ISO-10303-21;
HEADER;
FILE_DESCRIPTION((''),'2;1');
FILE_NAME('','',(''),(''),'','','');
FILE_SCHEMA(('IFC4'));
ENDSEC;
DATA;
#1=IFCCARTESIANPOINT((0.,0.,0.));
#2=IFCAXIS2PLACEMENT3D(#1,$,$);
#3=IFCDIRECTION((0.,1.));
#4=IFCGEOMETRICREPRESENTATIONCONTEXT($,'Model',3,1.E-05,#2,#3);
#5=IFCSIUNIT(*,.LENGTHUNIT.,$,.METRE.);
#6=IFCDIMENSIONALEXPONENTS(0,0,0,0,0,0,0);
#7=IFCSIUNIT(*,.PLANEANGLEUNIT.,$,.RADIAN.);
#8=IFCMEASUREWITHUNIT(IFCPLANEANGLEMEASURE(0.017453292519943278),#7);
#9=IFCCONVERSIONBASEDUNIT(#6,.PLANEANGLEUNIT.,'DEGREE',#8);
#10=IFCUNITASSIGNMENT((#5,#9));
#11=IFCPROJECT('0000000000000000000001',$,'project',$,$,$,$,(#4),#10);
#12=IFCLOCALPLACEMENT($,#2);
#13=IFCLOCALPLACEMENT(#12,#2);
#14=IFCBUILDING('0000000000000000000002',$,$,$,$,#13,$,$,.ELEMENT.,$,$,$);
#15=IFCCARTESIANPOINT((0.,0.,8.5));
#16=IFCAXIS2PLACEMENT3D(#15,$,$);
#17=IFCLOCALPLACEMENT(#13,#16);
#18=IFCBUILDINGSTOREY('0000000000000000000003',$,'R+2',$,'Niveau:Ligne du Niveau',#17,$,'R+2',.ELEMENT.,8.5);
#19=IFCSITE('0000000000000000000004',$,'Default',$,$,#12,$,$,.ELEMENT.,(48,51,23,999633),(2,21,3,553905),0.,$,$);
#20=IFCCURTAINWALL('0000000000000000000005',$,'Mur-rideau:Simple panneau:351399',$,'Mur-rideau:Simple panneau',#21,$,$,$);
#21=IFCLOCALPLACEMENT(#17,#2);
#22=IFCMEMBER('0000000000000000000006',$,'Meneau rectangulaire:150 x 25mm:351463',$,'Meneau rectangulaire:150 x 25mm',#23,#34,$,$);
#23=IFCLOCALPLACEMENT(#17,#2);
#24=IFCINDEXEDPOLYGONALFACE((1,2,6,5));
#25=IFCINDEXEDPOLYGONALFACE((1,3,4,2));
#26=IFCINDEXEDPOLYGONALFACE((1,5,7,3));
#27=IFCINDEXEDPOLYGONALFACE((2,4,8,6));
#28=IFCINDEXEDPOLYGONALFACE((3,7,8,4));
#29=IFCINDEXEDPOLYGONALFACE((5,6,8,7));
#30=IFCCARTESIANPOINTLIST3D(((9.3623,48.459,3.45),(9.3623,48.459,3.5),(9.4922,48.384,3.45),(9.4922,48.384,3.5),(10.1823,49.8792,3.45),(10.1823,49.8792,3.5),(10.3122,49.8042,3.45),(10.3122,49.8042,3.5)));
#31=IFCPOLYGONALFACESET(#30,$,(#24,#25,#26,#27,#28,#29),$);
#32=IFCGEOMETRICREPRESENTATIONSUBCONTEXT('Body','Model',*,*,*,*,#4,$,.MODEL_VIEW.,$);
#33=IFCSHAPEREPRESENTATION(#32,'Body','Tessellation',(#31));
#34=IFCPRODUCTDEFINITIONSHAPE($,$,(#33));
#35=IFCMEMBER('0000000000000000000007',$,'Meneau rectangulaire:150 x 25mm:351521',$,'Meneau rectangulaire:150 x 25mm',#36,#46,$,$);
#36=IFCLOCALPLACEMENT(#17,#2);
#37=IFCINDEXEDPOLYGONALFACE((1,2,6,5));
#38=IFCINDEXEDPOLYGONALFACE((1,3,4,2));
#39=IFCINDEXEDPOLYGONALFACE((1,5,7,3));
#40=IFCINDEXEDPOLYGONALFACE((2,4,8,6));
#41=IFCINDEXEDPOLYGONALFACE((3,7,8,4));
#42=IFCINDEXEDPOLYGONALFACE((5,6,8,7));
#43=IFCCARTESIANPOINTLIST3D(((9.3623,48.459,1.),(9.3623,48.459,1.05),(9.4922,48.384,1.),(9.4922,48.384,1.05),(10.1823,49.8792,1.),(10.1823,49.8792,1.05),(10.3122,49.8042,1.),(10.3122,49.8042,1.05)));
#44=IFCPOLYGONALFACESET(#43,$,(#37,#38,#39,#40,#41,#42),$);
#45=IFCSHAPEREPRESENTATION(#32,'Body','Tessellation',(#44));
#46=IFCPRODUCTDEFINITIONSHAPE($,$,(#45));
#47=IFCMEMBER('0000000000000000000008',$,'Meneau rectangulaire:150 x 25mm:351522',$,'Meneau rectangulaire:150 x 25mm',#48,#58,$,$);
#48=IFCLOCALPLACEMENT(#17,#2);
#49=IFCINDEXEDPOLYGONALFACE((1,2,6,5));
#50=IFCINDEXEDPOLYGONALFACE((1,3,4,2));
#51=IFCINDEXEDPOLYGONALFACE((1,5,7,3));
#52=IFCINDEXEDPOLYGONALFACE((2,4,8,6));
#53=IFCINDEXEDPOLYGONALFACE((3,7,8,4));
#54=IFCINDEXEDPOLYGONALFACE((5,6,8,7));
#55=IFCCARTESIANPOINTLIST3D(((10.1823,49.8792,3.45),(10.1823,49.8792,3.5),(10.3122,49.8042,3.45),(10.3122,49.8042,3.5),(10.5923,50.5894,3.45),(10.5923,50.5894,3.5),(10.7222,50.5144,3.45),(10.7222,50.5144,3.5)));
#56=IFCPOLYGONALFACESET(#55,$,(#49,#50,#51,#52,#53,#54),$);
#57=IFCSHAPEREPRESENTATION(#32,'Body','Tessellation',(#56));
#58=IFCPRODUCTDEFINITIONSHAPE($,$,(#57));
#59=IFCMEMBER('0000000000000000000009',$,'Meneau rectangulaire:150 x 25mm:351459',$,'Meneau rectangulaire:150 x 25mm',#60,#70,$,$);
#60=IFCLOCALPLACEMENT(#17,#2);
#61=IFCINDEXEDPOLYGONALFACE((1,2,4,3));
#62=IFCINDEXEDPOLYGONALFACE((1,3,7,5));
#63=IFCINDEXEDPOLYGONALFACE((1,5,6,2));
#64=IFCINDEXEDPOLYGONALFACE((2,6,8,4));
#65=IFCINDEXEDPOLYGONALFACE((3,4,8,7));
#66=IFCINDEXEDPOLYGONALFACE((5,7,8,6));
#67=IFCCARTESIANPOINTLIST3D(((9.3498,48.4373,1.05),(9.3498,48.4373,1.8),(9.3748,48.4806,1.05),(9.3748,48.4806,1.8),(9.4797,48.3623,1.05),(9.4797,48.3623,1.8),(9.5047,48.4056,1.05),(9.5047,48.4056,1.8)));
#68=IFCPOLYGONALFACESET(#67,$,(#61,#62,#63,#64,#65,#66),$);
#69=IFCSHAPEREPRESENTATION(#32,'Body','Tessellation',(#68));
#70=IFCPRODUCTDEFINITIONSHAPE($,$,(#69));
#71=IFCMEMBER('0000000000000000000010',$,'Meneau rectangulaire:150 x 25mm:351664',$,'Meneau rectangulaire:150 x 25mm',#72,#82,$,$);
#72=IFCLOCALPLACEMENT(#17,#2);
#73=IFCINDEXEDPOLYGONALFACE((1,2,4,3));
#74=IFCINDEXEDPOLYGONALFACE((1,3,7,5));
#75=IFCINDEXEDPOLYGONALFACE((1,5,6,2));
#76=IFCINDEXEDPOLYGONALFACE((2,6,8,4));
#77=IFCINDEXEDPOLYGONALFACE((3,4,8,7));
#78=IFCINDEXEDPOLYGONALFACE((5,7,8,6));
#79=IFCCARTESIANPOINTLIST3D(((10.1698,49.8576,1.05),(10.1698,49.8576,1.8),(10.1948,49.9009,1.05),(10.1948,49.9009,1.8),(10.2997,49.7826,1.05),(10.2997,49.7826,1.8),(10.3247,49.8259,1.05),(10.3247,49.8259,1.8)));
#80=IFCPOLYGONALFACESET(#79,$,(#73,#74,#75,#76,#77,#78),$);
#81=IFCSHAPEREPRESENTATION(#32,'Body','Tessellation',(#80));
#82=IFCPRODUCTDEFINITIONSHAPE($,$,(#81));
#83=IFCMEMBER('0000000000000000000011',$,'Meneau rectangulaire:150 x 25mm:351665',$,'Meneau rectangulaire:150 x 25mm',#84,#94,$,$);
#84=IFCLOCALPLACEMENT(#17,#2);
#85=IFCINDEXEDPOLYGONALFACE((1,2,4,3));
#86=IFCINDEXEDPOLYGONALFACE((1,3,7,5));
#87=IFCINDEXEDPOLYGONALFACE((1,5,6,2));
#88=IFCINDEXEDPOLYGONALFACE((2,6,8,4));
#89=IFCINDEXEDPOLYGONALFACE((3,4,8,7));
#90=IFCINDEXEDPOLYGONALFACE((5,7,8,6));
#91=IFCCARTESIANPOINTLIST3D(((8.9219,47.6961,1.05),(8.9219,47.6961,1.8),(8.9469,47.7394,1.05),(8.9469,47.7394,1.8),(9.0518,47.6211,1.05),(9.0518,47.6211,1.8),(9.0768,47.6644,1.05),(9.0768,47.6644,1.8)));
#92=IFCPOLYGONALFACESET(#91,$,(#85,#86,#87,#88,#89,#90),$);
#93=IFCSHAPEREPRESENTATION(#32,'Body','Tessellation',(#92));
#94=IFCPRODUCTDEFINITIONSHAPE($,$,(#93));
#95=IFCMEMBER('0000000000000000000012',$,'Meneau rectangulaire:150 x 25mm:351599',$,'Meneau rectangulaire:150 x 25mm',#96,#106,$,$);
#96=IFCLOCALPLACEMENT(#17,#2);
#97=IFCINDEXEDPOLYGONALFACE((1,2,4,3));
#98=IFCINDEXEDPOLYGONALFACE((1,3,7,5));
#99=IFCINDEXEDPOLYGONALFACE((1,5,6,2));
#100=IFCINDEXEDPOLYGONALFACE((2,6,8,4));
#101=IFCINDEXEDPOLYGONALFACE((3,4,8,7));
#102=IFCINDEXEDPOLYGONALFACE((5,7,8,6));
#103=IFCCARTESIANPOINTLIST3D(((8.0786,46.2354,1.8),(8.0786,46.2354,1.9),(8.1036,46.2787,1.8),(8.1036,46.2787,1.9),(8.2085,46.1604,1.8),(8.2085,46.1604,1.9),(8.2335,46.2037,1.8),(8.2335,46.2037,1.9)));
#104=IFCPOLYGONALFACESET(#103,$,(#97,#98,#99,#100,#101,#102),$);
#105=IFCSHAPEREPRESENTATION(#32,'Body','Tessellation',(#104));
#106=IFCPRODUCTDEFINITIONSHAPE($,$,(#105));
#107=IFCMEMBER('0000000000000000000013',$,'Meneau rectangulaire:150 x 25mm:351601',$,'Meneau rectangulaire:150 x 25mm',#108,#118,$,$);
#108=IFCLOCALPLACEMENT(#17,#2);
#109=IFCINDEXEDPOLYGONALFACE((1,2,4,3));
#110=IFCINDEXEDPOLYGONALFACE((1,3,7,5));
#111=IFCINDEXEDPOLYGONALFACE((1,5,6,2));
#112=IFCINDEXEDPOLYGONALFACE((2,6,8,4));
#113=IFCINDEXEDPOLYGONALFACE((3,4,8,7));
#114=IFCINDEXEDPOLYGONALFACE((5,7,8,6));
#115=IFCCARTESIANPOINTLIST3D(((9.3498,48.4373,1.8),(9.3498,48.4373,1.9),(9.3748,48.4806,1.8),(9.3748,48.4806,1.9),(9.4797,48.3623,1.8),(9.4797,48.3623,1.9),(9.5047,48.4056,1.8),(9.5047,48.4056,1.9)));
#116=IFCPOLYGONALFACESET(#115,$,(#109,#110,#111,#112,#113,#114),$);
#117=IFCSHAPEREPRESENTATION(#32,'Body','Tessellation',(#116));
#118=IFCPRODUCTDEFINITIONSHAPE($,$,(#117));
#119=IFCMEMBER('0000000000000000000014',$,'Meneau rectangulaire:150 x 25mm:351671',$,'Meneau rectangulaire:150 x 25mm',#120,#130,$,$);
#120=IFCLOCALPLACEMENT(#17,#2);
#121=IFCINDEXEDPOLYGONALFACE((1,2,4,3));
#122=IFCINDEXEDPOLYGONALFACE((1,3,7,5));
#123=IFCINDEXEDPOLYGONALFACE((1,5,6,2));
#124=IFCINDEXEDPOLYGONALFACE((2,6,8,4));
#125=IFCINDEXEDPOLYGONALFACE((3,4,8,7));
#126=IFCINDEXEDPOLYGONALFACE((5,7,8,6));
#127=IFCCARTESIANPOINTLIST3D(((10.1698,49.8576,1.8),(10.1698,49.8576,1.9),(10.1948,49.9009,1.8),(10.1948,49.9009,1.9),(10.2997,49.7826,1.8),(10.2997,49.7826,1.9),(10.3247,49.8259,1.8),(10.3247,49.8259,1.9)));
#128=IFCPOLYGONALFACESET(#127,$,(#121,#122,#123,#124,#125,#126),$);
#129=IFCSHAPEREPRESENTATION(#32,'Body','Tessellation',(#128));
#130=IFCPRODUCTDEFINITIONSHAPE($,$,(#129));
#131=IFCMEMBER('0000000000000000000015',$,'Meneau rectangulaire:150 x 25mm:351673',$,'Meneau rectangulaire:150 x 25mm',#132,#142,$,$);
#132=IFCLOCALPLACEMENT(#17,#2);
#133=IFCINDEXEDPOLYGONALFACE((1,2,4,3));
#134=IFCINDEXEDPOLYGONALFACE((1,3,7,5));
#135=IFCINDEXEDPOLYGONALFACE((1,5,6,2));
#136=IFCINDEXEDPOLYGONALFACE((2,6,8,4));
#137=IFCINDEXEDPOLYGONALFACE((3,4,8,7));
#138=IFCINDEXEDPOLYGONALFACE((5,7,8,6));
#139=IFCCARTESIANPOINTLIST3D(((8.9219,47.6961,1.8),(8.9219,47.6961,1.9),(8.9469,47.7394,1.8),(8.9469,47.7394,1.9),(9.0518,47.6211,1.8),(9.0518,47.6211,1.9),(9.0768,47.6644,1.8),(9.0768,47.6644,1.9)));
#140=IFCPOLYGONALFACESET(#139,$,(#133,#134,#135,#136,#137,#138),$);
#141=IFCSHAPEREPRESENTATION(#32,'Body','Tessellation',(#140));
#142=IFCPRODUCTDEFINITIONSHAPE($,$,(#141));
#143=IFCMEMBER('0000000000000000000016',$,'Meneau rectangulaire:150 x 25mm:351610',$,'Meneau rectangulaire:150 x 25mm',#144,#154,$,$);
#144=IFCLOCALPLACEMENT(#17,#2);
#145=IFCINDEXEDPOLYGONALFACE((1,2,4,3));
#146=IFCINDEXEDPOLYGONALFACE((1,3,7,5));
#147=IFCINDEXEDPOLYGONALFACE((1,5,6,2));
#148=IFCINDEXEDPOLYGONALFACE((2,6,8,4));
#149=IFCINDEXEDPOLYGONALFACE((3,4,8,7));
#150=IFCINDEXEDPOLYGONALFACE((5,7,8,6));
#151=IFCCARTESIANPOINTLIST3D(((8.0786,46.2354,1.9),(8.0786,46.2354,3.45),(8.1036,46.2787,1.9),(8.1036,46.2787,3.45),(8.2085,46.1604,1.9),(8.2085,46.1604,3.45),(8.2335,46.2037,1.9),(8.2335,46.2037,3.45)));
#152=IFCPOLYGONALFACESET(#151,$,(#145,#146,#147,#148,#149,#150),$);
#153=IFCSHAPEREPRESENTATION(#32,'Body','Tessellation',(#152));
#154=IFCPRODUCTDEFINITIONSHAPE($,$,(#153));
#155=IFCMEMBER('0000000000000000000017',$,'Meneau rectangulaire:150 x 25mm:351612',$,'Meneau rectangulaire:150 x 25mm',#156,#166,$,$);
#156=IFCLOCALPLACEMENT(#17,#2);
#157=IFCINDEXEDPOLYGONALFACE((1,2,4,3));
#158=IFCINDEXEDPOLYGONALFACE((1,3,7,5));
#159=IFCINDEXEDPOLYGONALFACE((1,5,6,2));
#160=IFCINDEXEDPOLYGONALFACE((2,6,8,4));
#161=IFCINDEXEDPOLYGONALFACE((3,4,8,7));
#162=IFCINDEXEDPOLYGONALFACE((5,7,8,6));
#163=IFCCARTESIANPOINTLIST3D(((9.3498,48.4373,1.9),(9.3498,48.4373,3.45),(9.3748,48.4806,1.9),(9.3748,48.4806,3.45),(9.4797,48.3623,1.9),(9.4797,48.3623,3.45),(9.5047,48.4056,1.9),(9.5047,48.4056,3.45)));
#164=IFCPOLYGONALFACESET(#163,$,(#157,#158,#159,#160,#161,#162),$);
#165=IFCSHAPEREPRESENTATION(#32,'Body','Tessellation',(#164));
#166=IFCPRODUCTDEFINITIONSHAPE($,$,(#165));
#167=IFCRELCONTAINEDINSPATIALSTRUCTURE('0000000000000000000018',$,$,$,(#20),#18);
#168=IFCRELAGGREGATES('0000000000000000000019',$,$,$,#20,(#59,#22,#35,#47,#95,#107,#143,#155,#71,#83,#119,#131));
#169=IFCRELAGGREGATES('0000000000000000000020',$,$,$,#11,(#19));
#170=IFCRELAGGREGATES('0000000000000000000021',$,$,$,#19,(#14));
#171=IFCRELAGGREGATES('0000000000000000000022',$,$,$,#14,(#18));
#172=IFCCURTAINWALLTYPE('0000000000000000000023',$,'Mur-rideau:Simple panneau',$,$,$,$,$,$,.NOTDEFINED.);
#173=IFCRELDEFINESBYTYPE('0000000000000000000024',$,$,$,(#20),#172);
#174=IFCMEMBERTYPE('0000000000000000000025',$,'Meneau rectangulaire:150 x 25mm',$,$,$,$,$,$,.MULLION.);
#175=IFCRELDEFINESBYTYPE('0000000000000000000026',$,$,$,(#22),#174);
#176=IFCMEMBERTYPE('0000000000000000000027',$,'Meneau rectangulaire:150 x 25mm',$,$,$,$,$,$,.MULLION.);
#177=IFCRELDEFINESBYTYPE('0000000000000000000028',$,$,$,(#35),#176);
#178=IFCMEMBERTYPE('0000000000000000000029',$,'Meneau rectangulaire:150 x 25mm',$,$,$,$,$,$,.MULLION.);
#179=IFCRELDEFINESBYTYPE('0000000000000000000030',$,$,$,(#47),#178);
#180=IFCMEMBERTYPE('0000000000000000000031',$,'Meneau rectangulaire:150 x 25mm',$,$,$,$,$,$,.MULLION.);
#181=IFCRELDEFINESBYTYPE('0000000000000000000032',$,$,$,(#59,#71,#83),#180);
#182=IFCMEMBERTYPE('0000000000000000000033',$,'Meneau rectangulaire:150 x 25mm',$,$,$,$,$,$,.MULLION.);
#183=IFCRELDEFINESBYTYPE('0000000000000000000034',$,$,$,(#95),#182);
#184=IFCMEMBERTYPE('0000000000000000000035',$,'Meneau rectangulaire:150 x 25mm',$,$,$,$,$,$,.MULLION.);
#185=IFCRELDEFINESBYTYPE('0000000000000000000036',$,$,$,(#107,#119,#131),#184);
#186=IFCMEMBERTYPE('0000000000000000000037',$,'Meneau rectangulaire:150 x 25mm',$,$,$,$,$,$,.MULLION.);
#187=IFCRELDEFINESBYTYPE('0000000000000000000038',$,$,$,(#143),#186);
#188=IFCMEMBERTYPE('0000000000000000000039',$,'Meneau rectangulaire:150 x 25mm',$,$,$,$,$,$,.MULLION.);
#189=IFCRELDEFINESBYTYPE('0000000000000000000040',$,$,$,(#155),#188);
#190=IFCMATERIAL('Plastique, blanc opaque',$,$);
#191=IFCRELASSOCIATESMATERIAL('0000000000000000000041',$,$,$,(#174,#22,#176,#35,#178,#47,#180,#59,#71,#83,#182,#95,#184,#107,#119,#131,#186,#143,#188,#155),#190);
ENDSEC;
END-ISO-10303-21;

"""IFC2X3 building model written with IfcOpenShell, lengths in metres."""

from ifc_helpers import new_model, entity, si_unit, converted_unit, direction, frame, origin, origin_2d_with_axis, place, context, subcontext, project, spatial, rectangle, extrude, source, transform, mapped, material, type_object, type_shapes, element, aggregate, save


model = new_model("IFC2X3")

# Units and contexts
model_context = context("Model", 3, precision=1e-05, world=origin(), true_north=direction((0.0, 1.0)))
body_context = subcontext(model_context, "Body", "Model", "MODEL_VIEW")
ifc_project = project(units=[si_unit("LENGTHUNIT", "METRE"), converted_unit("PLANEANGLEUNIT", "DEGREE", entity("IfcPlaneAngleMeasure", 0.017453292519943278), si_unit("PLANEANGLEUNIT", "RADIAN"), dimensions=[0, 0, 0, 0, 0, 0, 0])], contexts=[model_context])

# Site, building, storey
site_placement = place(None, origin())
site = spatial("IfcSite", under=ifc_project, at=site_placement, Name="Default", CompositionType="ELEMENT", RefLatitude=(48, 51, 23, 999633), RefLongitude=(2, 21, 3, 553905), RefElevation=0.0)
building_placement = place(site_placement, origin())
building = spatial("IfcBuilding", under=site, at=building_placement, CompositionType="ELEMENT")
storey_placement = place(building_placement, frame((0.0, 0.0, 8.5)))
storey = spatial("IfcBuildingStorey", under=building, at=storey_placement, Name="R+2", ObjectType="Niveau:Ligne du Niveau", LongName="R+2", CompositionType="ELEMENT", Elevation=8.5)

# Curtain wall, members
curtain_wall_type = type_object("IfcCurtainWallType", Name="Mur-rideau:Simple panneau", PredefinedType="NOTDEFINED")
curtain_wall_placement = place(storey_placement, frame((0.0, 0.0, -8.5)))
curtain_wall = element("IfcCurtainWall", 1, at=curtain_wall_placement, inside=storey, type_object=curtain_wall_type, Name="Mur-rideau:Simple panneau:351399", ObjectType="Mur-rideau:Simple panneau")
ifc_material_1 = material(Name="Plastique, blanc opaque")
member_type_1 = type_object("IfcMemberType", Name="Meneau rectangulaire:150 x 25mm", PredefinedType="MULLION", material=ifc_material_1)
shared_shape_1 = source(origin(), body_context, "Body", "SweptSolid", [
    extrude(rectangle(XDim=0.05, YDim=0.15, at=origin_2d_with_axis()), frame((-0.025, 0.0, -1.64), z_axis=(0.0, 0.0, 1.0), x_axis=(-1.0, 0.0, 0.0)), (0.0, 0.0, 1.0), 1.64),
])
type_shapes(member_type_1, [shared_shape_1])
member_1_placement = place(curtain_wall_placement, frame((9.4273, 48.4215, 12.0), z_axis=(-0.5, -0.866025, 0.0), x_axis=(0.0, 0.0, 1.0)))
member_1 = element("IfcMember", 2, at=member_1_placement, type_object=member_type_1, material=ifc_material_1, Name="Meneau rectangulaire:150 x 25mm:351463", ObjectType="Meneau rectangulaire:150 x 25mm", context=body_context, shape_type="MappedRepresentation", body=[
    mapped(shared_shape_1, transform((0.0, 0.0, 0.0), scale=1.0)),
])
member_type_2 = type_object("IfcMemberType", Name="Meneau rectangulaire:150 x 25mm", PredefinedType="MULLION", material=ifc_material_1)
shared_shape_2 = source(origin(), body_context, "Body", "SweptSolid", [
    extrude(rectangle(XDim=0.05, YDim=0.15, at=origin_2d_with_axis()), frame((-0.025, 0.0, -1.64), z_axis=(0.0, 0.0, 1.0), x_axis=(-1.0, 0.0, 0.0)), (0.0, 0.0, 1.0), 1.64),
])
type_shapes(member_type_2, [shared_shape_2])
member_2_placement = place(curtain_wall_placement, frame((10.2473, 49.8417, 9.5), z_axis=(0.5, 0.866025, 0.0), x_axis=(0.0, 0.0, -1.0)))
member_2 = element("IfcMember", 3, at=member_2_placement, type_object=member_type_2, material=ifc_material_1, Name="Meneau rectangulaire:150 x 25mm:351521", ObjectType="Meneau rectangulaire:150 x 25mm", context=body_context, shape_type="MappedRepresentation", body=[
    mapped(shared_shape_2, transform((0.0, 0.0, 0.0), scale=1.0)),
])
member_type_3 = type_object("IfcMemberType", Name="Meneau rectangulaire:150 x 25mm", PredefinedType="MULLION", material=ifc_material_1)
shared_shape_3 = source(origin(), body_context, "Body", "SweptSolid", [
    extrude(rectangle(XDim=0.05, YDim=0.15, at=origin_2d_with_axis()), frame((-0.025, 0.0, -0.82), z_axis=(0.0, 0.0, 1.0), x_axis=(-1.0, 0.0, 0.0)), (0.0, 0.0, 1.0), 0.82),
])
type_shapes(member_type_3, [shared_shape_3])
member_3_placement = place(curtain_wall_placement, frame((10.2473, 49.8417, 12.0), z_axis=(-0.5, -0.866025, 0.0), x_axis=(0.0, 0.0, 1.0)))
member_3 = element("IfcMember", 4, at=member_3_placement, type_object=member_type_3, material=ifc_material_1, Name="Meneau rectangulaire:150 x 25mm:351522", ObjectType="Meneau rectangulaire:150 x 25mm", context=body_context, shape_type="MappedRepresentation", body=[
    mapped(shared_shape_3, transform((0.0, 0.0, 0.0), scale=1.0)),
])
member_type_4 = type_object("IfcMemberType", Name="Meneau rectangulaire:150 x 25mm", PredefinedType="MULLION", material=ifc_material_1)
shared_shape_4 = source(origin(), body_context, "Body", "SweptSolid", [
    extrude(rectangle(XDim=0.05, YDim=0.15, at=origin_2d_with_axis()), frame((0.0, 0.0, -0.75), z_axis=(0.0, 0.0, 1.0), x_axis=(-1.0, 0.0, 0.0)), (0.0, 0.0, 1.0), 0.75),
])
type_shapes(member_type_4, [shared_shape_4])
member_4_placement = place(curtain_wall_placement, frame((9.4273, 48.4215, 9.55), z_axis=(0.0, 0.0, -1.0), x_axis=(-0.5, -0.866025, 0.0)))
member_4 = element("IfcMember", 5, at=member_4_placement, type_object=member_type_4, material=ifc_material_1, Name="Meneau rectangulaire:150 x 25mm:351459", ObjectType="Meneau rectangulaire:150 x 25mm", context=body_context, shape_type="MappedRepresentation", body=[
    mapped(shared_shape_4, transform((0.0, 0.0, 0.0), scale=1.0)),
])
member_5_placement = place(curtain_wall_placement, frame((10.2473, 49.8417, 9.55), z_axis=(0.0, 0.0, -1.0), x_axis=(-0.5, -0.866025, 0.0)))
member_5 = element("IfcMember", 6, at=member_5_placement, type_object=member_type_4, material=ifc_material_1, Name="Meneau rectangulaire:150 x 25mm:351664", ObjectType="Meneau rectangulaire:150 x 25mm", context=body_context, shape_type="MappedRepresentation", body=[
    mapped(shared_shape_4, transform((0.0, 0.0, 0.0), scale=1.0)),
])
member_6_placement = place(curtain_wall_placement, frame((8.9994, 47.6803, 9.55), z_axis=(0.0, 0.0, -1.0), x_axis=(-0.5, -0.866025, 0.0)))
member_6 = element("IfcMember", 7, at=member_6_placement, type_object=member_type_4, material=ifc_material_1, Name="Meneau rectangulaire:150 x 25mm:351665", ObjectType="Meneau rectangulaire:150 x 25mm", context=body_context, shape_type="MappedRepresentation", body=[
    mapped(shared_shape_4, transform((0.0, 0.0, 0.0), scale=1.0)),
])
member_type_5 = type_object("IfcMemberType", Name="Meneau rectangulaire:150 x 25mm", PredefinedType="MULLION", material=ifc_material_1)
shared_shape_5 = source(origin(), body_context, "Body", "SweptSolid", [
    extrude(rectangle(XDim=0.05, YDim=0.15, at=origin_2d_with_axis()), frame((-0.025, 0.0, -0.1), z_axis=(0.0, 0.0, 1.0), x_axis=(-1.0, 0.0, 0.0)), (0.0, 0.0, 1.0), 0.1),
])
type_shapes(member_type_5, [shared_shape_5])
member_7_placement = place(curtain_wall_placement, frame((8.1435, 46.1979, 10.3), z_axis=(0.0, 0.0, -1.0), x_axis=(-0.5, -0.866025, 0.0)))
member_7 = element("IfcMember", 8, at=member_7_placement, type_object=member_type_5, material=ifc_material_1, Name="Meneau rectangulaire:150 x 25mm:351599", ObjectType="Meneau rectangulaire:150 x 25mm", context=body_context, shape_type="MappedRepresentation", body=[
    mapped(shared_shape_5, transform((0.0, 0.0, 0.0), scale=1.0)),
])
member_type_6 = type_object("IfcMemberType", Name="Meneau rectangulaire:150 x 25mm", PredefinedType="MULLION", material=ifc_material_1)
shared_shape_6 = source(origin(), body_context, "Body", "SweptSolid", [
    extrude(rectangle(XDim=0.05, YDim=0.15, at=origin_2d_with_axis()), frame((0.0, 0.0, -0.1), z_axis=(0.0, 0.0, 1.0), x_axis=(-1.0, 0.0, 0.0)), (0.0, 0.0, 1.0), 0.1),
])
type_shapes(member_type_6, [shared_shape_6])
member_8_placement = place(curtain_wall_placement, frame((9.4273, 48.4215, 10.3), z_axis=(0.0, 0.0, -1.0), x_axis=(-0.5, -0.866025, 0.0)))
member_8 = element("IfcMember", 9, at=member_8_placement, type_object=member_type_6, material=ifc_material_1, Name="Meneau rectangulaire:150 x 25mm:351601", ObjectType="Meneau rectangulaire:150 x 25mm", context=body_context, shape_type="MappedRepresentation", body=[
    mapped(shared_shape_6, transform((0.0, 0.0, 0.0), scale=1.0)),
])
member_9_placement = place(curtain_wall_placement, frame((10.2473, 49.8417, 10.3), z_axis=(0.0, 0.0, -1.0), x_axis=(-0.5, -0.866025, 0.0)))
member_9 = element("IfcMember", 10, at=member_9_placement, type_object=member_type_6, material=ifc_material_1, Name="Meneau rectangulaire:150 x 25mm:351671", ObjectType="Meneau rectangulaire:150 x 25mm", context=body_context, shape_type="MappedRepresentation", body=[
    mapped(shared_shape_6, transform((0.0, 0.0, 0.0), scale=1.0)),
])
member_10_placement = place(curtain_wall_placement, frame((8.9994, 47.6803, 10.3), z_axis=(0.0, 0.0, -1.0), x_axis=(-0.5, -0.866025, 0.0)))
member_10 = element("IfcMember", 11, at=member_10_placement, type_object=member_type_6, material=ifc_material_1, Name="Meneau rectangulaire:150 x 25mm:351673", ObjectType="Meneau rectangulaire:150 x 25mm", context=body_context, shape_type="MappedRepresentation", body=[
    mapped(shared_shape_6, transform((0.0, 0.0, 0.0), scale=1.0)),
])
member_type_7 = type_object("IfcMemberType", Name="Meneau rectangulaire:150 x 25mm", PredefinedType="MULLION", material=ifc_material_1)
shared_shape_7 = source(origin(), body_context, "Body", "SweptSolid", [
    extrude(rectangle(XDim=0.05, YDim=0.15, at=origin_2d_with_axis()), frame((-0.025, 0.0, -1.55), z_axis=(0.0, 0.0, 1.0), x_axis=(-1.0, 0.0, 0.0)), (0.0, 0.0, 1.0), 1.55),
])
type_shapes(member_type_7, [shared_shape_7])
member_11_placement = place(curtain_wall_placement, frame((8.1435, 46.1979, 10.4), z_axis=(0.0, 0.0, -1.0), x_axis=(-0.5, -0.866025, 0.0)))
member_11 = element("IfcMember", 12, at=member_11_placement, type_object=member_type_7, material=ifc_material_1, Name="Meneau rectangulaire:150 x 25mm:351610", ObjectType="Meneau rectangulaire:150 x 25mm", context=body_context, shape_type="MappedRepresentation", body=[
    mapped(shared_shape_7, transform((0.0, 0.0, 0.0), scale=1.0)),
])
member_type_8 = type_object("IfcMemberType", Name="Meneau rectangulaire:150 x 25mm", PredefinedType="MULLION", material=ifc_material_1)
shared_shape_8 = source(origin(), body_context, "Body", "SweptSolid", [
    extrude(rectangle(XDim=0.05, YDim=0.15, at=origin_2d_with_axis()), frame((0.0, 0.0, -1.55), z_axis=(0.0, 0.0, 1.0), x_axis=(-1.0, 0.0, 0.0)), (0.0, 0.0, 1.0), 1.55),
])
type_shapes(member_type_8, [shared_shape_8])
member_12_placement = place(curtain_wall_placement, frame((9.4273, 48.4215, 10.4), z_axis=(0.0, 0.0, -1.0), x_axis=(-0.5, -0.866025, 0.0)))
member_12 = element("IfcMember", 13, at=member_12_placement, type_object=member_type_8, material=ifc_material_1, Name="Meneau rectangulaire:150 x 25mm:351612", ObjectType="Meneau rectangulaire:150 x 25mm", context=body_context, shape_type="MappedRepresentation", body=[
    mapped(shared_shape_8, transform((0.0, 0.0, 0.0), scale=1.0)),
])
aggregate(curtain_wall, [member_4, member_1, member_2, member_3, member_7, member_8, member_11, member_12, member_5, member_6, member_9, member_10])

save(model, "model.ifc")
